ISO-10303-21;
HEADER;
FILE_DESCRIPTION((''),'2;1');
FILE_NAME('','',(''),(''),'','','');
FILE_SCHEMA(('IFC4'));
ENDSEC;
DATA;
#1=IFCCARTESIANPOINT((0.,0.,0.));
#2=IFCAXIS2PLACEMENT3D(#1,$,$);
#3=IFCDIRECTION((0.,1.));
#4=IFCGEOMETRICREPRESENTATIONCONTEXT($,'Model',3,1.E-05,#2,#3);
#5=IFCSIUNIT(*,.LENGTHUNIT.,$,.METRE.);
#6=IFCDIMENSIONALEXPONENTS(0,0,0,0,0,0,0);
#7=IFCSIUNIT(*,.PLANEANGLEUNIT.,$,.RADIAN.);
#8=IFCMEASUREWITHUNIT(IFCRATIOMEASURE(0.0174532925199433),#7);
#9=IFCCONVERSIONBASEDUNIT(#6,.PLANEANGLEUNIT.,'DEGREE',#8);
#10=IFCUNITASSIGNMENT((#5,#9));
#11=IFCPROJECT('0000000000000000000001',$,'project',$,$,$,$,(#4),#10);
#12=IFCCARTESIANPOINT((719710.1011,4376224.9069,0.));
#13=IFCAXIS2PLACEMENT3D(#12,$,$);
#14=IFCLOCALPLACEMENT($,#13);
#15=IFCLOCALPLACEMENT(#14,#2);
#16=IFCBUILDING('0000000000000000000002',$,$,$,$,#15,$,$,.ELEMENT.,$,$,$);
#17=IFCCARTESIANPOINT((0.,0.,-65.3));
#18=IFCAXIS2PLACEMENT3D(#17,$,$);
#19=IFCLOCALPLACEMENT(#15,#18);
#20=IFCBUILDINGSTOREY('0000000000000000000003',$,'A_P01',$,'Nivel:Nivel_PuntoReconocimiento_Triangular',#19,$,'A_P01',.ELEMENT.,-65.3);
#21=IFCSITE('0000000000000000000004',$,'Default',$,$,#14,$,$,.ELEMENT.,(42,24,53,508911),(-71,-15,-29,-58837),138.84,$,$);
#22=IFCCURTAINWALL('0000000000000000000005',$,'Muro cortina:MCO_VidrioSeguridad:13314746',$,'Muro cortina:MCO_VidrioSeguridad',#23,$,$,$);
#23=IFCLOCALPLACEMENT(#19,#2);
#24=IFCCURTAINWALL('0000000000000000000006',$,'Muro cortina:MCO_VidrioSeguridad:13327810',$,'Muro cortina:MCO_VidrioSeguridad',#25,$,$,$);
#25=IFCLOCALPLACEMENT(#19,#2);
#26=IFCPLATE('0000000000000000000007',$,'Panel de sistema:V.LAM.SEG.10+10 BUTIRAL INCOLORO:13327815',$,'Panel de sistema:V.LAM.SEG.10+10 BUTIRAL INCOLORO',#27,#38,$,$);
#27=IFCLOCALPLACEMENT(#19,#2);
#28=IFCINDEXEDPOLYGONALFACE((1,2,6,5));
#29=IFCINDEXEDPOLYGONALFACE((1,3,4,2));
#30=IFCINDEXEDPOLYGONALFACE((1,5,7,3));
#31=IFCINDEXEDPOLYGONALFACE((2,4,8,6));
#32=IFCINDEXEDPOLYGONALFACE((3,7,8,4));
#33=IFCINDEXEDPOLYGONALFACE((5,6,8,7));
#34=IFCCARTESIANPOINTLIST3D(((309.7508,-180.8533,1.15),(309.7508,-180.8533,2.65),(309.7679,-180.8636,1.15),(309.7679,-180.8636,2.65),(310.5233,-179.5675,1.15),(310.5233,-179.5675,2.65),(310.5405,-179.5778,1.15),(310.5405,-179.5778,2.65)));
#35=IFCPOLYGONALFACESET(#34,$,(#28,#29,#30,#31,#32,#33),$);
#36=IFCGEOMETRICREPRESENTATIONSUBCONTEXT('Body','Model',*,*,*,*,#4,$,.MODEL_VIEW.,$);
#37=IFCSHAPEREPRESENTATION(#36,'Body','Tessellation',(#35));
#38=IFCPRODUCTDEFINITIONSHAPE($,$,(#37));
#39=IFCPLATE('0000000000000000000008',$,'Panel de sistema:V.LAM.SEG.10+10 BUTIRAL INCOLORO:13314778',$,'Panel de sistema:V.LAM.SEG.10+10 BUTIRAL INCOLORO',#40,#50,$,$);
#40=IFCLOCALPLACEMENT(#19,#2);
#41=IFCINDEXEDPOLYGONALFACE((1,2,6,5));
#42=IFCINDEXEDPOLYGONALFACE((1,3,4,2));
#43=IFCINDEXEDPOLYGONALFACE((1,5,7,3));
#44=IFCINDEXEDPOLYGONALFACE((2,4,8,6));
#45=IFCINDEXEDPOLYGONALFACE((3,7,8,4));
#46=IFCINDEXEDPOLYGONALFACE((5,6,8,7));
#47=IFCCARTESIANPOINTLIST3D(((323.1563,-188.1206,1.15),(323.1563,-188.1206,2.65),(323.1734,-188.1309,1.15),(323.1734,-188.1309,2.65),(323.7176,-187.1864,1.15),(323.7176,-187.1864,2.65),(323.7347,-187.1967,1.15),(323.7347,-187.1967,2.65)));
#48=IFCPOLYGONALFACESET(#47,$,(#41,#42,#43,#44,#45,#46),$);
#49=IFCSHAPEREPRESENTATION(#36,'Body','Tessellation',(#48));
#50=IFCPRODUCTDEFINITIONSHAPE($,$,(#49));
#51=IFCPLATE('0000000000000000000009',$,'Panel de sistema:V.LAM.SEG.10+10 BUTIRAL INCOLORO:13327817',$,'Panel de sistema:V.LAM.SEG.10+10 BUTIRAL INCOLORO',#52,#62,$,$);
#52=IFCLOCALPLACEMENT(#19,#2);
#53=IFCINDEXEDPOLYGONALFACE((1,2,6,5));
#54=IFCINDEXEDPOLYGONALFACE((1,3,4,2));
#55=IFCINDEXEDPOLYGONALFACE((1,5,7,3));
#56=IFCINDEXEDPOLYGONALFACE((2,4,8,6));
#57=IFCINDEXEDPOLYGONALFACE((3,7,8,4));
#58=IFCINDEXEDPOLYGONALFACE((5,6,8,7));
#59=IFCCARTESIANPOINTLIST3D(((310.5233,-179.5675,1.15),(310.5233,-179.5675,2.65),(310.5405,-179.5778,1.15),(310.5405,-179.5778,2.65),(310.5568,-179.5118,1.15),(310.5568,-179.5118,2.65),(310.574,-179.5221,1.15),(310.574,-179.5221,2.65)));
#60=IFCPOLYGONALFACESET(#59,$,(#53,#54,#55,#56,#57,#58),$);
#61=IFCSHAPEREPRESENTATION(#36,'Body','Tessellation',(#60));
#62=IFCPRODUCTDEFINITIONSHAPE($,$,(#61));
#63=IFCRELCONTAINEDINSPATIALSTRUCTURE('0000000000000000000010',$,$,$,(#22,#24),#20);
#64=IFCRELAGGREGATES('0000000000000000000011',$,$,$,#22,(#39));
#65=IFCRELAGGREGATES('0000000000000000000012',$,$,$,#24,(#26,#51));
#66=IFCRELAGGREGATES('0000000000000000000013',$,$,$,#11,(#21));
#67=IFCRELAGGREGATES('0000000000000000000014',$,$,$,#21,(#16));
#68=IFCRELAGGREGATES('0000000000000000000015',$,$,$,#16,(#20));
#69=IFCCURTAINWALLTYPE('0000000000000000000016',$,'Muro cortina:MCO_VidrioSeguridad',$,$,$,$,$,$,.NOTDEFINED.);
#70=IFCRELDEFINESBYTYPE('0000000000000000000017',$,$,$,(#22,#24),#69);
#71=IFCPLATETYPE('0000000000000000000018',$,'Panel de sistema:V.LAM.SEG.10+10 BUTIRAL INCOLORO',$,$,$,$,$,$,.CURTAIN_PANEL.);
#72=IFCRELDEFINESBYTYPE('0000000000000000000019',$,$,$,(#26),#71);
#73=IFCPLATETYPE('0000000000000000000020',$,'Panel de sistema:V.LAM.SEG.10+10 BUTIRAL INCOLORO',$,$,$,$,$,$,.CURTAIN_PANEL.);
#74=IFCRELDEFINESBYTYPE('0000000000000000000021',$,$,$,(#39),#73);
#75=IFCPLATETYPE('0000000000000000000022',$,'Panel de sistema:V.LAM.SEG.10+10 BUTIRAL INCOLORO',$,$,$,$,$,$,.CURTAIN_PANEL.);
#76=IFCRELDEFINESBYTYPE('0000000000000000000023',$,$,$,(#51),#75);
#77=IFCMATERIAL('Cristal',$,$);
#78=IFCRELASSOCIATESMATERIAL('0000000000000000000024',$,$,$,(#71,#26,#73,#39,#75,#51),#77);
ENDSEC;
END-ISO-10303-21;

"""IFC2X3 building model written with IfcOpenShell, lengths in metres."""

from ifc_helpers import new_model, entity, si_unit, converted_unit, direction, frame, frame_2d, origin, origin_2d_with_axis, place, context, subcontext, project, spatial, rectangle, extrude, source, transform, mapped, material, type_object, type_shapes, element, aggregate, save


model = new_model("IFC2X3")

# Units and contexts
model_context = context("Model", 3, precision=1e-05, world=origin(), true_north=direction((0.0, 1.0)))
body_context = subcontext(model_context, "Body", "Model", "MODEL_VIEW")
ifc_project = project(units=[si_unit("LENGTHUNIT", "METRE"), converted_unit("PLANEANGLEUNIT", "DEGREE", entity("IfcRatioMeasure", 0.0174532925199433), si_unit("PLANEANGLEUNIT", "RADIAN"), dimensions=[0, 0, 0, 0, 0, 0, 0])], contexts=[model_context])

# Site, building, storey
site_placement = place(None, frame((719710.1011, 4376224.9069, 0.0)))
site = spatial("IfcSite", under=ifc_project, at=site_placement, Name="Default", CompositionType="ELEMENT", RefLatitude=(42, 24, 53, 508911), RefLongitude=(-71, -15, -29, -58837), RefElevation=138.84)
building_placement = place(site_placement, origin())
building = spatial("IfcBuilding", under=site, at=building_placement, CompositionType="ELEMENT")
storey_placement = place(building_placement, frame((0.0, 0.0, -65.3)))
storey = spatial("IfcBuildingStorey", under=building, at=storey_placement, Name="A_P01", ObjectType="Nivel:Nivel_PuntoReconocimiento_Triangular", LongName="A_P01", CompositionType="ELEMENT", Elevation=-65.3)

# Shared definitions
curtain_wall_type = type_object("IfcCurtainWallType", Name="Muro cortina:MCO_VidrioSeguridad", PredefinedType="NOTDEFINED")
ifc_material_1 = material(Name="Cristal")

# Curtain walls, plate
curtain_wall_1_placement = place(storey_placement, frame((0.0, 0.0, 65.3)))
curtain_wall_1 = element("IfcCurtainWall", 1, at=curtain_wall_1_placement, inside=storey, type_object=curtain_wall_type, Name="Muro cortina:MCO_VidrioSeguridad:13314746", ObjectType="Muro cortina:MCO_VidrioSeguridad")
plate_type_1 = type_object("IfcPlateType", Name="Panel de sistema:V.LAM.SEG.10+10 BUTIRAL INCOLORO", PredefinedType="CURTAIN_PANEL", material=ifc_material_1)
shared_shape_1 = source(origin(), body_context, "Body", "SweptSolid", [
    extrude(rectangle(XDim=0.02, YDim=1.5, at=frame_2d((0.0, 0.0), x_axis=(1.0, 0.0))), frame((0.0, 0.0, 0.0), z_axis=(0.0, 0.0, 1.0), x_axis=(0.0, 1.0, 0.0)), (0.0, 0.0, 1.0), 1.5),
])
type_shapes(plate_type_1, [shared_shape_1])
curtain_wall_2_placement = place(storey_placement, frame((0.0, 0.0, 65.3)))
curtain_wall_2 = element("IfcCurtainWall", 2, at=curtain_wall_2_placement, inside=storey, type_object=curtain_wall_type, Name="Muro cortina:MCO_VidrioSeguridad:13327810", ObjectType="Muro cortina:MCO_VidrioSeguridad")
plate_1_placement = place(curtain_wall_2_placement, frame((310.1456, -180.2156, -64.15), z_axis=(0.0, 0.0, 1.0), x_axis=(0.515038, 0.857167, 0.0)))
plate_1 = element("IfcPlate", 3, at=plate_1_placement, type_object=plate_type_1, material=ifc_material_1, Name="Panel de sistema:V.LAM.SEG.10+10 BUTIRAL INCOLORO:13327815", ObjectType="Panel de sistema:V.LAM.SEG.10+10 BUTIRAL INCOLORO", context=body_context, shape_type="MappedRepresentation", body=[
    mapped(shared_shape_1, transform((0.0, 0.0, 0.0), scale=1.0)),
])

# Plates
plate_type_2 = type_object("IfcPlateType", Name="Panel de sistema:V.LAM.SEG.10+10 BUTIRAL INCOLORO", PredefinedType="CURTAIN_PANEL", material=ifc_material_1)
shared_shape_2 = source(origin(), body_context, "Body", "SweptSolid", [
    extrude(rectangle(XDim=0.02, YDim=1.0899, at=origin_2d_with_axis()), frame((0.0, 0.0, 0.0), z_axis=(0.0, 0.0, 1.0), x_axis=(0.0, 1.0, 0.0)), (0.0, 0.0, 1.0), 1.5),
])
type_shapes(plate_type_2, [shared_shape_2])
plate_2_placement = place(curtain_wall_1_placement, frame((323.4455, -187.6586, -64.15), z_axis=(0.0, 0.0, 1.0), x_axis=(0.515038, 0.857167, 0.0)))
plate_2 = element("IfcPlate", 4, at=plate_2_placement, type_object=plate_type_2, material=ifc_material_1, Name="Panel de sistema:V.LAM.SEG.10+10 BUTIRAL INCOLORO:13314778", ObjectType="Panel de sistema:V.LAM.SEG.10+10 BUTIRAL INCOLORO", context=body_context, shape_type="MappedRepresentation", body=[
    mapped(shared_shape_2, transform((0.0, 0.0, 0.0), scale=1.0)),
])
aggregate(curtain_wall_1, [plate_2])
plate_type_3 = type_object("IfcPlateType", Name="Panel de sistema:V.LAM.SEG.10+10 BUTIRAL INCOLORO", PredefinedType="CURTAIN_PANEL", material=ifc_material_1)
shared_shape_3 = source(origin(), body_context, "Body", "SweptSolid", [
    extrude(rectangle(XDim=0.02, YDim=0.065, at=origin_2d_with_axis()), frame((0.0, 0.0, 0.0), z_axis=(0.0, 0.0, 1.0), x_axis=(0.0, 1.0, 0.0)), (0.0, 0.0, 1.0), 1.5),
])
type_shapes(plate_type_3, [shared_shape_3])
plate_3_placement = place(curtain_wall_2_placement, frame((310.5487, -179.5448, -64.15), z_axis=(0.0, 0.0, 1.0), x_axis=(0.515038, 0.857167, 0.0)))
plate_3 = element("IfcPlate", 5, at=plate_3_placement, type_object=plate_type_3, material=ifc_material_1, Name="Panel de sistema:V.LAM.SEG.10+10 BUTIRAL INCOLORO:13327817", ObjectType="Panel de sistema:V.LAM.SEG.10+10 BUTIRAL INCOLORO", context=body_context, shape_type="MappedRepresentation", body=[
    mapped(shared_shape_3, transform((0.0, 0.0, 0.0), scale=1.0)),
])
aggregate(curtain_wall_2, [plate_1, plate_3])

save(model, "model.ifc")
